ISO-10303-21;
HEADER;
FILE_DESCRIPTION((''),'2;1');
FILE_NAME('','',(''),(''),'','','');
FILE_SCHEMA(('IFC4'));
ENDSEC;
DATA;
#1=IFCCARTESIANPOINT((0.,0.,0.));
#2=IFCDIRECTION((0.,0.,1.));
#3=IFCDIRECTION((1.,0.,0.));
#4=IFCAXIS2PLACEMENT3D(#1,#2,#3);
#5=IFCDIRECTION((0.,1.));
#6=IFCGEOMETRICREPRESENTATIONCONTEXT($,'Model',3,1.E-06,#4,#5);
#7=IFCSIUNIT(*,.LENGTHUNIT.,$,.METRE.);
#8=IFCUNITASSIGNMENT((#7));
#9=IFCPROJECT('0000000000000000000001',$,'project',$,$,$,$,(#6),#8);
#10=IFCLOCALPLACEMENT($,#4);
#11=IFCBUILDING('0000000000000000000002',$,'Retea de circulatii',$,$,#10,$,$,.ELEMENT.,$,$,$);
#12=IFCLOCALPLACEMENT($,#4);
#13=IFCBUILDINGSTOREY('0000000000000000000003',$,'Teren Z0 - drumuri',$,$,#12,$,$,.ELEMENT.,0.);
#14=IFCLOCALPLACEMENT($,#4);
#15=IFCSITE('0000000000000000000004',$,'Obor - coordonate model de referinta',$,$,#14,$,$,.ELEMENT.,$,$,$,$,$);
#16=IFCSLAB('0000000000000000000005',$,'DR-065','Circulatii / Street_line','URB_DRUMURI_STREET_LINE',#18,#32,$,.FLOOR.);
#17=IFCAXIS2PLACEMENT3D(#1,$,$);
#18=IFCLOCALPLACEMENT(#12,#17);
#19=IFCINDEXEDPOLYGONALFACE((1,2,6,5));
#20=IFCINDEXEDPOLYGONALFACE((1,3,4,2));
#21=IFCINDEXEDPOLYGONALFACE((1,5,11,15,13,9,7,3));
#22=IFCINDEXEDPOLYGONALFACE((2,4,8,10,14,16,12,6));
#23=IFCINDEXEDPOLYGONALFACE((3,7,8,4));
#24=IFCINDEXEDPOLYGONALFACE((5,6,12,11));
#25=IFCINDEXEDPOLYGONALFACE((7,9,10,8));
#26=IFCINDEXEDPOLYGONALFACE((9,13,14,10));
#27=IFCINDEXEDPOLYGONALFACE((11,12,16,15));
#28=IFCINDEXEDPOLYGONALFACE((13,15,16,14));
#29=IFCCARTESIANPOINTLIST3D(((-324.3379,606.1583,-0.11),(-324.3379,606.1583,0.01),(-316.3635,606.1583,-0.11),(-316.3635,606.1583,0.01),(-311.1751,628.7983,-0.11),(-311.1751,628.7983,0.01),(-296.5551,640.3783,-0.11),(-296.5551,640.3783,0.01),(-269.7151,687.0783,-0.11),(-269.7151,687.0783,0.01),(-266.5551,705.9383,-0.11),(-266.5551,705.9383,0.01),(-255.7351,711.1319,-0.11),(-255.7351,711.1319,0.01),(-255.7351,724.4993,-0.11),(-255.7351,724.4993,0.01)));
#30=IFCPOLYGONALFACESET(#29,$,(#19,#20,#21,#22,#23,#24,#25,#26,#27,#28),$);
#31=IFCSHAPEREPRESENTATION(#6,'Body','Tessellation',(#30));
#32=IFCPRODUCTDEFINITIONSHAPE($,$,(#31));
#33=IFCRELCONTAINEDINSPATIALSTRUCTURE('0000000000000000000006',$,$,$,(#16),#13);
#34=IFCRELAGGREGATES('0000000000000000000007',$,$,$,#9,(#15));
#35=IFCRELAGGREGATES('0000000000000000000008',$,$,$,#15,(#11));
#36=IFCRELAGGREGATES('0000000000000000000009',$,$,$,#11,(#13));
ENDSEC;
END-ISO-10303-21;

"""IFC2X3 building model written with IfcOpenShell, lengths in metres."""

from ifc_helpers import new_model, si_unit, direction, frame, origin_with_axes, place, context, project, spatial, polyline, outline, extrude, element, save


model = new_model("IFC2X3")

# Units and contexts
model_context = context("Model", 3, precision=1e-06, world=origin_with_axes(), true_north=direction((0.0, 1.0)))
ifc_project = project(units=[si_unit("LENGTHUNIT", "METRE")], contexts=[model_context])

# Site, building, storey
site_placement = place(None, origin_with_axes())
site = spatial("IfcSite", under=ifc_project, at=site_placement, Name="Obor - coordonate model de referinta", CompositionType="ELEMENT")
building_placement = place(None, origin_with_axes())
building = spatial("IfcBuilding", under=site, at=building_placement, Name="Retea de circulatii", CompositionType="ELEMENT")
storey_placement = place(None, origin_with_axes())
storey = spatial("IfcBuildingStorey", under=building, at=storey_placement, Name="Teren Z0 - drumuri", CompositionType="ELEMENT", Elevation=0.0)

# Slab
slab_1_placement = place(None, origin_with_axes())
element("IfcSlab", 1, at=slab_1_placement, inside=storey, Name="DR-065", Description="Circulatii / Street_line", ObjectType="URB_DRUMURI_STREET_LINE", PredefinedType="FLOOR", context=model_context, shape_type="SweptSolid", body=[
    extrude(outline(polyline([(-255.7351, 711.1319), (-255.7351, 724.4993), (-266.5551, 705.9383), (-311.1751, 628.7983), (-324.3379, 606.1583), (-316.3635, 606.1583), (-296.5551, 640.3783), (-269.7151, 687.0783), (-255.7351, 711.1319)])), frame((0.0, 0.0, -0.11), z_axis=(0.0, 0.0, 1.0), x_axis=(1.0, 0.0, 0.0)), (0.0, 0.0, 1.0), 0.12),
])

save(model, "model.ifc")
